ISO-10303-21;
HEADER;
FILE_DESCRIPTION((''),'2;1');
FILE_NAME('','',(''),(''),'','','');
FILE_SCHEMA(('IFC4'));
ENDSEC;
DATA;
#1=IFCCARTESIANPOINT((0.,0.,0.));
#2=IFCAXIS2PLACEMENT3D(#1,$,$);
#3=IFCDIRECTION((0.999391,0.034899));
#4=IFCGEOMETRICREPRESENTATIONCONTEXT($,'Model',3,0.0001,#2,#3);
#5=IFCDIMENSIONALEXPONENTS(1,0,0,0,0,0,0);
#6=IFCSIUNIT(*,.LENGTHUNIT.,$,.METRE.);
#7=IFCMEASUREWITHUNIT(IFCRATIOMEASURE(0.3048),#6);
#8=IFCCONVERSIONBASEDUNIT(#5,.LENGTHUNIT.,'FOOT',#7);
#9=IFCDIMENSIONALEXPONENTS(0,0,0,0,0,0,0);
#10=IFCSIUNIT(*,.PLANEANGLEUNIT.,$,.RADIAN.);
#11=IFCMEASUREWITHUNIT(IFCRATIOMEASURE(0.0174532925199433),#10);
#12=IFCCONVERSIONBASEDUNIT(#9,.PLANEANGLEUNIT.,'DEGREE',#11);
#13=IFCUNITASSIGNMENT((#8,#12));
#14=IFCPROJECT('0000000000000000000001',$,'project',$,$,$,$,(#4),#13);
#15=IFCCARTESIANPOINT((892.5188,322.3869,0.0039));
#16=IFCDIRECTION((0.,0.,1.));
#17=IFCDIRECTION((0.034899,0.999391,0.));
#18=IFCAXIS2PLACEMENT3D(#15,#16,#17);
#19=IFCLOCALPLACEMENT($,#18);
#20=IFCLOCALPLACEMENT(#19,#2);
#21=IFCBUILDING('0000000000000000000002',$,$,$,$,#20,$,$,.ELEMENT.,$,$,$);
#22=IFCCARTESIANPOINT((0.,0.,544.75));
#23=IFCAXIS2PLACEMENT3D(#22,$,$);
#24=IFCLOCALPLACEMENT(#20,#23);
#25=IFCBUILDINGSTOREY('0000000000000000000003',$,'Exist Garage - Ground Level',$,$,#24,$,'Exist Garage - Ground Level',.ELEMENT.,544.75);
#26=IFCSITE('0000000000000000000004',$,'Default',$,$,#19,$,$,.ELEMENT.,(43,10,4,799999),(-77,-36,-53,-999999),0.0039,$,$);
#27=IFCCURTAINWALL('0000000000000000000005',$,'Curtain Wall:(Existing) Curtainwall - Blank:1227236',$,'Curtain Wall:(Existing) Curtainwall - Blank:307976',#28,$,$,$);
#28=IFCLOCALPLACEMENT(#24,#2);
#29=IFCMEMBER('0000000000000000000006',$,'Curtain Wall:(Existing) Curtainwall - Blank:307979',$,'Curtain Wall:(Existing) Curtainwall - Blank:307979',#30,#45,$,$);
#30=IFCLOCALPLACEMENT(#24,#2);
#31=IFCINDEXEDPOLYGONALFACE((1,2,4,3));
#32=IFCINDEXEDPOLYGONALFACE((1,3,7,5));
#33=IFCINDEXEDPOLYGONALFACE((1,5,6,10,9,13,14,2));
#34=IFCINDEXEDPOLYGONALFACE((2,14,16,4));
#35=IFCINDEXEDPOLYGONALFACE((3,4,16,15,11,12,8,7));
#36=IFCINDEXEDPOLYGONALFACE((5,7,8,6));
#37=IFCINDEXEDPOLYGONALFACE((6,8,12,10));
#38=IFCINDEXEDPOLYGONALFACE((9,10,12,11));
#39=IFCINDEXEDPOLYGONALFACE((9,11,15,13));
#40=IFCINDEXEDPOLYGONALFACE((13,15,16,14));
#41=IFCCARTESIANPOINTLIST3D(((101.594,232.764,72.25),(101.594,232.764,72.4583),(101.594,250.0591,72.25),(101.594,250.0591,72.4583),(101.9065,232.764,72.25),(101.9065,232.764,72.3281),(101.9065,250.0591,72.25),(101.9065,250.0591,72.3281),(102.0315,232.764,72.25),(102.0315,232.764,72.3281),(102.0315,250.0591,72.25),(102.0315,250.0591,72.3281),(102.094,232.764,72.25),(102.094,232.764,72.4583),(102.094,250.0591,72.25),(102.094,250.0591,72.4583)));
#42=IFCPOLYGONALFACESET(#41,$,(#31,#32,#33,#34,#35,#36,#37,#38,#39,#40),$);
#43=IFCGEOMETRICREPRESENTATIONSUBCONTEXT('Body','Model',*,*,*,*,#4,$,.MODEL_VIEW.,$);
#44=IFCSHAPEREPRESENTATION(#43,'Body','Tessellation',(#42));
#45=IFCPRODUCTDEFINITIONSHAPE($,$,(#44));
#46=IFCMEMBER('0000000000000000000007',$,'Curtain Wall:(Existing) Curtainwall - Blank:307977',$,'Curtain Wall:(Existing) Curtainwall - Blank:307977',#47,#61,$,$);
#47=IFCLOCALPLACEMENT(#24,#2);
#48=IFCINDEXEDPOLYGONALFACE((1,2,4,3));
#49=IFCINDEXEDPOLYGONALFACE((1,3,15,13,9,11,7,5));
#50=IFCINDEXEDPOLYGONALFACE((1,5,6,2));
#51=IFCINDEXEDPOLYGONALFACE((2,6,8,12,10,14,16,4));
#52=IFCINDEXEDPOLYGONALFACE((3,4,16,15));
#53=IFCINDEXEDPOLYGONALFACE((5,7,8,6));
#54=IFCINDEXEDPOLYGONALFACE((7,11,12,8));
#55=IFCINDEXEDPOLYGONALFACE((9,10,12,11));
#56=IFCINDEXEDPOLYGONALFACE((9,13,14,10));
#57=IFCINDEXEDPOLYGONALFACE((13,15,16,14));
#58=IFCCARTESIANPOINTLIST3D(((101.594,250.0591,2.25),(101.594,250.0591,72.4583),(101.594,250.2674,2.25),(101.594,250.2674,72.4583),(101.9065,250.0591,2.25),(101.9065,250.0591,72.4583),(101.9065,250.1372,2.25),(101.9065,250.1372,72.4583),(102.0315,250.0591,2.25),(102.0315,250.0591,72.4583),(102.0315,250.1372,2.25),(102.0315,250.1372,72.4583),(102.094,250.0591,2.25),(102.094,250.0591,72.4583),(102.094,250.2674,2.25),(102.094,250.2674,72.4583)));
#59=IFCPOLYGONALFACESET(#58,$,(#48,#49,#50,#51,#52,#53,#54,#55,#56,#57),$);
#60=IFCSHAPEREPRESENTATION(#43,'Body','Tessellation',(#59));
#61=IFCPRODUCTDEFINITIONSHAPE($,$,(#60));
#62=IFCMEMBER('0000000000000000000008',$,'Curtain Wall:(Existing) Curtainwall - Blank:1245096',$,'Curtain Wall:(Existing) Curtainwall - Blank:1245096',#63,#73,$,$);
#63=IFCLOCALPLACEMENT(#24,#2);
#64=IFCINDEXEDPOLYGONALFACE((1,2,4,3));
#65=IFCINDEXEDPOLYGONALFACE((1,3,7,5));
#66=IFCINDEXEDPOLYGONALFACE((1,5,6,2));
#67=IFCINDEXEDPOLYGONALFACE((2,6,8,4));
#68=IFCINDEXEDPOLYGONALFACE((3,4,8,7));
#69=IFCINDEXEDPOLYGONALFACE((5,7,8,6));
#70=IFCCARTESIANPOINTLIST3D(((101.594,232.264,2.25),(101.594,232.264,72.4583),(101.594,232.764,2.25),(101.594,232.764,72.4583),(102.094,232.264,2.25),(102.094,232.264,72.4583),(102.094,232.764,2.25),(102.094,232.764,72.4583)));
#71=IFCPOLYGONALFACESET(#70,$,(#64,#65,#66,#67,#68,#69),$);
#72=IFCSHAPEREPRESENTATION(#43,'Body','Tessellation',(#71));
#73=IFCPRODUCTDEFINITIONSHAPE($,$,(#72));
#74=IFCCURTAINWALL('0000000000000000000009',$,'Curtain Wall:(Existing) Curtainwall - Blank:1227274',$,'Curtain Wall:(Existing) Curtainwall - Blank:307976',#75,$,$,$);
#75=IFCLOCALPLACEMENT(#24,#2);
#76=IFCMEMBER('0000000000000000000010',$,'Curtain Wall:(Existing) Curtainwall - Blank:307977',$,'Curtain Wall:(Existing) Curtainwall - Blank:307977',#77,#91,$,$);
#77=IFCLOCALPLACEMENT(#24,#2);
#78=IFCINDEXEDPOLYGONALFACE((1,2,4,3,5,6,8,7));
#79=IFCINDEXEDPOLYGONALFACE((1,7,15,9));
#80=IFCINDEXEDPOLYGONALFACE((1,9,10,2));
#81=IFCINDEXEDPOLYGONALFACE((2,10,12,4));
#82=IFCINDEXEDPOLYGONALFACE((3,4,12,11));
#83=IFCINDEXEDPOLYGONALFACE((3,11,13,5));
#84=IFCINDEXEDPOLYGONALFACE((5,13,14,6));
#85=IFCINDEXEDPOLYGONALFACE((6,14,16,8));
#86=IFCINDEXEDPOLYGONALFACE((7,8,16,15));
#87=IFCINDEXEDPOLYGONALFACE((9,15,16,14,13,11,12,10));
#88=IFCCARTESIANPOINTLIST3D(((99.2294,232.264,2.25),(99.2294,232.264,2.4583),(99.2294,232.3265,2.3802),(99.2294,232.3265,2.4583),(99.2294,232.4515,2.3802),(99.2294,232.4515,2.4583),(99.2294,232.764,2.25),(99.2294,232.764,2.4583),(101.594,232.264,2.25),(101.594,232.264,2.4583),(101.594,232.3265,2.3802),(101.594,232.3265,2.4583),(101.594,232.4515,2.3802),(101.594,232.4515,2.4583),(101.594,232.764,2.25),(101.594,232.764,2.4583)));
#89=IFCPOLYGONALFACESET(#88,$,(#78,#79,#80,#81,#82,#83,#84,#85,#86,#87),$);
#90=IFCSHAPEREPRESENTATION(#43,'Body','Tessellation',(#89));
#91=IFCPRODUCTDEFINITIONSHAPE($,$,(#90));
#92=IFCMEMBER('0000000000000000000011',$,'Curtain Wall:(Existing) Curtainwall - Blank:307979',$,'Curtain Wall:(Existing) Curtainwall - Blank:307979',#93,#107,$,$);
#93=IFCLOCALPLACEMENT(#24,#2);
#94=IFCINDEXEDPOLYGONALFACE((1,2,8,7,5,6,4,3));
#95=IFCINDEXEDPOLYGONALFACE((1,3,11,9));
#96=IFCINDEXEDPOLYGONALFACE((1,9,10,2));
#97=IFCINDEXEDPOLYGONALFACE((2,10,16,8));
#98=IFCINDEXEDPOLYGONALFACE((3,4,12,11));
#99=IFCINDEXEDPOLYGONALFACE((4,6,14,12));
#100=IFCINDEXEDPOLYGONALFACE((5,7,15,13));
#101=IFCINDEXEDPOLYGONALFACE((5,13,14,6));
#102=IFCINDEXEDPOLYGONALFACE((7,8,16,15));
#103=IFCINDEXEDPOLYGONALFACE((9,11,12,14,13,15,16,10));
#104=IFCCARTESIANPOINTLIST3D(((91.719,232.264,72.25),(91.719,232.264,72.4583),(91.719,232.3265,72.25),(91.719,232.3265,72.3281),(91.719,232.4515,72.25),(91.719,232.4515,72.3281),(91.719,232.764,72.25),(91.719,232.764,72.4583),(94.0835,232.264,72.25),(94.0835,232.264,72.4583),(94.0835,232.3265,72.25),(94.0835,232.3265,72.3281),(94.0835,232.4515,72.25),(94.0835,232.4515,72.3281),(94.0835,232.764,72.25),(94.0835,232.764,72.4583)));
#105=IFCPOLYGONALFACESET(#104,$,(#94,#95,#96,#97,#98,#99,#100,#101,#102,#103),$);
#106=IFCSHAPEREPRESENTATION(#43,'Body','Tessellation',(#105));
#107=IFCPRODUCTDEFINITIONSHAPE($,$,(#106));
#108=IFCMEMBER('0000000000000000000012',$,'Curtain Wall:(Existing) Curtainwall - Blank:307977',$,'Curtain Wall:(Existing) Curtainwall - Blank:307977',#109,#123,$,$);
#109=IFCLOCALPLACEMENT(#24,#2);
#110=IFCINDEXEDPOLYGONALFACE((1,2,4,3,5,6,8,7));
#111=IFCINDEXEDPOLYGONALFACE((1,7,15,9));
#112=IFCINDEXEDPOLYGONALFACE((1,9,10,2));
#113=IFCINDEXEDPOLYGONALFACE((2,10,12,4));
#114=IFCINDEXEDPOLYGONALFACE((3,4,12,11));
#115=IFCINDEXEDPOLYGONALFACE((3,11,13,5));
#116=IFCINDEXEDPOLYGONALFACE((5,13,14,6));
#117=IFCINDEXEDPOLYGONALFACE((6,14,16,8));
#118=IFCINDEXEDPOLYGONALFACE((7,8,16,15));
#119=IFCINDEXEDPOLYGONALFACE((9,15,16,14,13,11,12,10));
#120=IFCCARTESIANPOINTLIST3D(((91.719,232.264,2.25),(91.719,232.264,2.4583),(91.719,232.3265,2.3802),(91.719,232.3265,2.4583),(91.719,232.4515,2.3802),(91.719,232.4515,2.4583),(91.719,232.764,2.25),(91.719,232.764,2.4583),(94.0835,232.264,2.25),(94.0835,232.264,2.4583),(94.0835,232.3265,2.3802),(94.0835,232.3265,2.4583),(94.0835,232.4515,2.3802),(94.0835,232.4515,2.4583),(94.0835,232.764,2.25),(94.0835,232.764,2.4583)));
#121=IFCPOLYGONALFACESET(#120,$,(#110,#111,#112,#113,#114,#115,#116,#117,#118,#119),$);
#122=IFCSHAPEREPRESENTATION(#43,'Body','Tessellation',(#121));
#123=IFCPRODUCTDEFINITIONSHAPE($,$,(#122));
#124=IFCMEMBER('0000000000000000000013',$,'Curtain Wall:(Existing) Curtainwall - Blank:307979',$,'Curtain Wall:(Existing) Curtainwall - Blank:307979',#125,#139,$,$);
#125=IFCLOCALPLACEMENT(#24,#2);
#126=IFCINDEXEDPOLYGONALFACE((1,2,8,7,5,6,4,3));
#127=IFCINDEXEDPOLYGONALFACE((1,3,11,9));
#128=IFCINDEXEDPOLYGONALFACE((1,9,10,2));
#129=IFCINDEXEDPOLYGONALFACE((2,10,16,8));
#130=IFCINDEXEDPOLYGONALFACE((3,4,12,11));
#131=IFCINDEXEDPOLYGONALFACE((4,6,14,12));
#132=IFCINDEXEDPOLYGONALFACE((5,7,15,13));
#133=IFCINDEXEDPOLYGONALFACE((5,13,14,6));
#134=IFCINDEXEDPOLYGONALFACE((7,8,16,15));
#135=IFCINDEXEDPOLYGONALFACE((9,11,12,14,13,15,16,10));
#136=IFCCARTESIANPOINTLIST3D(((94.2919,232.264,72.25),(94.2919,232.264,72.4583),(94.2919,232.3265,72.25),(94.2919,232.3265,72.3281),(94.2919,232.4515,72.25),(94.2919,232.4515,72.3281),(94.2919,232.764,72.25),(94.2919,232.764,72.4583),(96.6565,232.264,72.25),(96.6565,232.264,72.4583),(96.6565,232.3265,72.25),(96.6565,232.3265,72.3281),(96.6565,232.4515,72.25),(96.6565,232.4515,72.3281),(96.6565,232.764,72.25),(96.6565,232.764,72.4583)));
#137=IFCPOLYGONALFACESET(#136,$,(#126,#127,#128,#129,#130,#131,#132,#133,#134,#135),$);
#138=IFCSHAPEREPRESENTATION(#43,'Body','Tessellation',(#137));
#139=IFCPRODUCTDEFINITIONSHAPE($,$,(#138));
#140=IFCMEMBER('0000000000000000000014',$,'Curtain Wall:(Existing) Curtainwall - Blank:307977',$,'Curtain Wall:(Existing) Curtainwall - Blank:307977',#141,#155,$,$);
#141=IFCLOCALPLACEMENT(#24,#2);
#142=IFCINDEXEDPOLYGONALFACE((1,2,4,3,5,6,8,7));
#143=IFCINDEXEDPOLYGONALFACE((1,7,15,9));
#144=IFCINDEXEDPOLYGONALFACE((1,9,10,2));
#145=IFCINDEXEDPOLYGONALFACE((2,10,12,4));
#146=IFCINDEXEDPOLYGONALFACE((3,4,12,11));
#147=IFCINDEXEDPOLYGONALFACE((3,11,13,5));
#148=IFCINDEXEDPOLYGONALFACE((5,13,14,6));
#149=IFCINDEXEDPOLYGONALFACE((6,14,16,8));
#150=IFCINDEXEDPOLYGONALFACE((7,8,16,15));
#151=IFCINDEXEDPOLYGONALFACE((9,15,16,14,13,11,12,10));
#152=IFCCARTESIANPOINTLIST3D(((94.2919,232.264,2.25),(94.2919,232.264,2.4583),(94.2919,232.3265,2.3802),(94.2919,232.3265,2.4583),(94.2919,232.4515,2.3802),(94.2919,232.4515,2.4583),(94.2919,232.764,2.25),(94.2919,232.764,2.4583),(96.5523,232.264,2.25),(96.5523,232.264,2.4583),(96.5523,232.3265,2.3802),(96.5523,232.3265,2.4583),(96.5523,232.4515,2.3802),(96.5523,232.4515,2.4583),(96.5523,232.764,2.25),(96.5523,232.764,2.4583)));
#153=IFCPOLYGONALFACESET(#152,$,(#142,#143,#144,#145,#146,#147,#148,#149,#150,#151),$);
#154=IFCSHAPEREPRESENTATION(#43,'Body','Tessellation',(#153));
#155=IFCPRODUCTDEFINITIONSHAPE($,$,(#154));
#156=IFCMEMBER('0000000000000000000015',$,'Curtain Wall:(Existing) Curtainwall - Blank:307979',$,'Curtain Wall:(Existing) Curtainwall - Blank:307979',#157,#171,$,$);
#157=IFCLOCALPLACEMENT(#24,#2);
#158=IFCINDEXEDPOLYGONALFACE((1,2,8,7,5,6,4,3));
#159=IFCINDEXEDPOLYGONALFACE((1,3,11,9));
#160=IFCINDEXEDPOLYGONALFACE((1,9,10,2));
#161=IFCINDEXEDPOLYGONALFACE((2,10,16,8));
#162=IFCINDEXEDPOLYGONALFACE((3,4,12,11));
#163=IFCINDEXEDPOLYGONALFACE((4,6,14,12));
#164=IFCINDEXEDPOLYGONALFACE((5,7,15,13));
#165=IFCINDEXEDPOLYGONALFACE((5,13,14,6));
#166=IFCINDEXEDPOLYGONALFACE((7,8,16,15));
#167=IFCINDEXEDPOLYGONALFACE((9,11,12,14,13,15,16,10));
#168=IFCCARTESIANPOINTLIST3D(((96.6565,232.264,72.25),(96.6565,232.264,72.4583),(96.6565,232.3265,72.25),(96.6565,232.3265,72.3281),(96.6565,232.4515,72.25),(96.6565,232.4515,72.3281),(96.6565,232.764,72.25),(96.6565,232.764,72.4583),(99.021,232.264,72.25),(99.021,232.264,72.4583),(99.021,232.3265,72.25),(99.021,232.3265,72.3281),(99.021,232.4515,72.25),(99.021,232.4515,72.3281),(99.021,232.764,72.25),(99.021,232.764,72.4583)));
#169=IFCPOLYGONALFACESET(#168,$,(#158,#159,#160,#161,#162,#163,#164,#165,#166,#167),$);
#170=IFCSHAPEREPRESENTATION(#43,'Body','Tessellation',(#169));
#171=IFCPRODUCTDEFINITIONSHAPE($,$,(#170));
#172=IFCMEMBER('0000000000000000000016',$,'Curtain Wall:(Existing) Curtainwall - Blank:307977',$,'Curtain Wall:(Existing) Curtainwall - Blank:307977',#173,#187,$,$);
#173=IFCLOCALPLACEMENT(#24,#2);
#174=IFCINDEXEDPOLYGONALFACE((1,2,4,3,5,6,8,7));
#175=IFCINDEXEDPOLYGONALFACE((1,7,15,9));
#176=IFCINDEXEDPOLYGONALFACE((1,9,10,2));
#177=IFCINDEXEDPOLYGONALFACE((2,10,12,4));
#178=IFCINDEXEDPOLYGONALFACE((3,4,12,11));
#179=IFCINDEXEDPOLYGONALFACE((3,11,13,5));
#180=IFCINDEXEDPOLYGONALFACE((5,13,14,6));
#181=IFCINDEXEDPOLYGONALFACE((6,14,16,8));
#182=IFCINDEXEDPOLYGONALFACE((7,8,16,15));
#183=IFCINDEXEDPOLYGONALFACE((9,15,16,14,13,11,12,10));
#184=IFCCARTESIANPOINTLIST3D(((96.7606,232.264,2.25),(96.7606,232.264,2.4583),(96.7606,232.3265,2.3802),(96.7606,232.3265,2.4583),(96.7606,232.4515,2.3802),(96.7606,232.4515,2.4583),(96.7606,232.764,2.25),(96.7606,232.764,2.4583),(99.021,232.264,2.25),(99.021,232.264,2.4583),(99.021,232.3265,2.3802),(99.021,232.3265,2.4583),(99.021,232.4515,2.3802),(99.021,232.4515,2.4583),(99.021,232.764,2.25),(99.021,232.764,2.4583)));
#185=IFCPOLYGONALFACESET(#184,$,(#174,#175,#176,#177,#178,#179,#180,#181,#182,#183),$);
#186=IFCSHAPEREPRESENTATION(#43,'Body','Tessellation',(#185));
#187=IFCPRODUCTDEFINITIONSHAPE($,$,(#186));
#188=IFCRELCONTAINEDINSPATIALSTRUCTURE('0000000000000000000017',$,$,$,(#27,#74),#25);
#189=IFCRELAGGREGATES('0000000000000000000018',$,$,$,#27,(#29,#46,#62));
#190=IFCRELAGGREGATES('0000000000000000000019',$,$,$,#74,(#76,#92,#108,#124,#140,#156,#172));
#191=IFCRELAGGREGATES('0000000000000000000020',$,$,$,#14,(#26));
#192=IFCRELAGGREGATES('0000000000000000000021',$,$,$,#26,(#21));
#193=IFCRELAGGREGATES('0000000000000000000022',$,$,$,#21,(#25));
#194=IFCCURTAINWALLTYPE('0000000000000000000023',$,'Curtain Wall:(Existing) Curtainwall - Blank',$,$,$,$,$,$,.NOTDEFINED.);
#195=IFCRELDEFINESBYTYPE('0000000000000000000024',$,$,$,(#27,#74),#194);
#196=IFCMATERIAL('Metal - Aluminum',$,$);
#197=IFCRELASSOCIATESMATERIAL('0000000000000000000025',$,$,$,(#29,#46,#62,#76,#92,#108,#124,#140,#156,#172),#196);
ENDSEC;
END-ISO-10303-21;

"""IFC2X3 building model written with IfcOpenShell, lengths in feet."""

from ifc_helpers import new_model, entity, si_unit, converted_unit, direction, frame, origin, origin_2d_with_axis, place, context, subcontext, project, spatial, polyline, rectangle, outline, extrude, material, type_object, element, aggregate, save


model = new_model("IFC2X3")

# Units and contexts
model_context = context("Model", 3, precision=0.0001, world=origin(), true_north=direction((0.999391, 0.034899)))
body_context = subcontext(model_context, "Body", "Model", "MODEL_VIEW")
ifc_project = project(units=[converted_unit("LENGTHUNIT", "FOOT", entity("IfcRatioMeasure", 0.3048), si_unit("LENGTHUNIT", "METRE"), dimensions=[1, 0, 0, 0, 0, 0, 0]), converted_unit("PLANEANGLEUNIT", "DEGREE", entity("IfcRatioMeasure", 0.0174532925199433), si_unit("PLANEANGLEUNIT", "RADIAN"), dimensions=[0, 0, 0, 0, 0, 0, 0])], contexts=[model_context])

# Site, building, storey
site_placement = place(None, frame((892.5188, 322.3869, 0.0039), z_axis=(0.0, 0.0, 1.0), x_axis=(0.034899, 0.999391, 0.0)))
site = spatial("IfcSite", under=ifc_project, at=site_placement, Name="Default", CompositionType="ELEMENT", RefLatitude=(43, 10, 4, 799999), RefLongitude=(-77, -36, -53, -999999), RefElevation=0.0039)
building_placement = place(site_placement, origin())
building = spatial("IfcBuilding", under=site, at=building_placement, CompositionType="ELEMENT")
storey_placement = place(building_placement, frame((0.0, 0.0, 544.75)))
storey = spatial("IfcBuildingStorey", under=building, at=storey_placement, Name="Exist Garage - Ground Level", LongName="Exist Garage - Ground Level", CompositionType="ELEMENT", Elevation=544.75)

# Curtain walls, members
curtain_wall_type = type_object("IfcCurtainWallType", Name="Curtain Wall:(Existing) Curtainwall - Blank", PredefinedType="NOTDEFINED")
curtain_wall_1_placement = place(storey_placement, frame((0.0, 0.0, -544.75)))
curtain_wall_1 = element("IfcCurtainWall", 1, at=curtain_wall_1_placement, inside=storey, type_object=curtain_wall_type, Name="Curtain Wall:(Existing) Curtainwall - Blank:1227236", ObjectType="Curtain Wall:(Existing) Curtainwall - Blank:307976")
ifc_material_1 = material(Name="Metal - Aluminum")
member_1_placement = place(curtain_wall_1_placement, frame((0.0, 0.0, 544.75)))
member_1 = element("IfcMember", 2, at=member_1_placement, material=ifc_material_1, Name="Curtain Wall:(Existing) Curtainwall - Blank:307979", ObjectType="Curtain Wall:(Existing) Curtainwall - Blank:307979", context=body_context, shape_type="SweptSolid", body=[
    extrude(outline(polyline([(-0.1367, -0.1875), (0.0716, -0.1875), (0.0716, -0.125), (-0.0065, -0.125), (-0.0065, 0.0), (0.0716, 0.0), (0.0716, 0.3125), (-0.1367, 0.3125), (-0.1367, -0.1875)])), frame((101.9065, 232.764, 72.3216), z_axis=(0.0, 1.0, 0.0), x_axis=(0.0, 0.0, -1.0)), (0.0, 0.0, 1.0), 17.2951),
])
member_2_placement = place(curtain_wall_1_placement, frame((0.0, 0.0, 544.75)))
member_2 = element("IfcMember", 3, at=member_2_placement, material=ifc_material_1, Name="Curtain Wall:(Existing) Curtainwall - Blank:307977", ObjectType="Curtain Wall:(Existing) Curtainwall - Blank:307977", context=body_context, shape_type="SweptSolid", body=[
    extrude(outline(polyline([(0.0, -0.0716), (0.3125, -0.0716), (0.3125, 0.1367), (-0.1875, 0.1367), (-0.1875, -0.0716), (-0.125, -0.0716), (-0.125, 0.0065), (0.0, 0.0065), (0.0, -0.0716)])), frame((101.9065, 250.1307, 72.4583), z_axis=(0.0, 0.0, -1.0), x_axis=(-1.0, 0.0, 0.0)), (0.0, 0.0, 1.0), 70.2083),
])
member_3_placement = place(curtain_wall_1_placement, frame((0.0, 0.0, 544.75)))
member_3 = element("IfcMember", 4, at=member_3_placement, material=ifc_material_1, Name="Curtain Wall:(Existing) Curtainwall - Blank:1245096", ObjectType="Curtain Wall:(Existing) Curtainwall - Blank:1245096", context=body_context, shape_type="SweptSolid", body=[
    extrude(rectangle(XDim=0.5, YDim=0.5, at=origin_2d_with_axis()), frame((101.844, 232.514, 2.25), z_axis=(0.0, 0.0, 1.0), x_axis=(-1.0, 0.0, 0.0)), (0.0, 0.0, 1.0), 70.2083),
])
aggregate(curtain_wall_1, [member_1, member_2, member_3])
curtain_wall_2_placement = place(storey_placement, frame((0.0, 0.0, -544.75)))
curtain_wall_2 = element("IfcCurtainWall", 5, at=curtain_wall_2_placement, inside=storey, type_object=curtain_wall_type, Name="Curtain Wall:(Existing) Curtainwall - Blank:1227274", ObjectType="Curtain Wall:(Existing) Curtainwall - Blank:307976")
member_4_placement = place(curtain_wall_2_placement, frame((0.0, 0.0, 544.75)))
member_4 = element("IfcMember", 6, at=member_4_placement, material=ifc_material_1, Name="Curtain Wall:(Existing) Curtainwall - Blank:307977", ObjectType="Curtain Wall:(Existing) Curtainwall - Blank:307977", context=body_context, shape_type="SweptSolid", body=[
    extrude(outline(polyline([(-0.0716, -0.3125), (0.1367, -0.3125), (0.1367, 0.1875), (-0.0716, 0.1875), (-0.0716, 0.125), (0.0065, 0.125), (0.0065, 0.0), (-0.0716, 0.0), (-0.0716, -0.3125)])), frame((101.594, 232.4515, 2.3867), z_axis=(-1.0, 0.0, 0.0), x_axis=(0.0, 0.0, -1.0)), (0.0, 0.0, 1.0), 2.3646),
])
member_5_placement = place(curtain_wall_2_placement, frame((0.0, 0.0, 544.75)))
member_5 = element("IfcMember", 7, at=member_5_placement, material=ifc_material_1, Name="Curtain Wall:(Existing) Curtainwall - Blank:307979", ObjectType="Curtain Wall:(Existing) Curtainwall - Blank:307979", context=body_context, shape_type="SweptSolid", body=[
    extrude(outline(polyline([(-0.1367, -0.1875), (0.0716, -0.1875), (0.0716, -0.125), (-0.0065, -0.125), (-0.0065, 0.0), (0.0716, 0.0), (0.0716, 0.3125), (-0.1367, 0.3125), (-0.1367, -0.1875)])), frame((91.719, 232.4515, 72.3216), z_axis=(1.0, 0.0, 0.0), x_axis=(0.0, 0.0, -1.0)), (0.0, 0.0, 1.0), 2.3646),
])
member_6_placement = place(curtain_wall_2_placement, frame((0.0, 0.0, 544.75)))
member_6 = element("IfcMember", 8, at=member_6_placement, material=ifc_material_1, Name="Curtain Wall:(Existing) Curtainwall - Blank:307977", ObjectType="Curtain Wall:(Existing) Curtainwall - Blank:307977", context=body_context, shape_type="SweptSolid", body=[
    extrude(outline(polyline([(-0.0716, -0.3125), (0.1367, -0.3125), (0.1367, 0.1875), (-0.0716, 0.1875), (-0.0716, 0.125), (0.0065, 0.125), (0.0065, 0.0), (-0.0716, 0.0), (-0.0716, -0.3125)])), frame((94.0835, 232.4515, 2.3867), z_axis=(-1.0, 0.0, 0.0), x_axis=(0.0, 0.0, -1.0)), (0.0, 0.0, 1.0), 2.3646),
])
member_7_placement = place(curtain_wall_2_placement, frame((0.0, 0.0, 544.75)))
member_7 = element("IfcMember", 9, at=member_7_placement, material=ifc_material_1, Name="Curtain Wall:(Existing) Curtainwall - Blank:307979", ObjectType="Curtain Wall:(Existing) Curtainwall - Blank:307979", context=body_context, shape_type="SweptSolid", body=[
    extrude(outline(polyline([(-0.1367, -0.1875), (0.0716, -0.1875), (0.0716, -0.125), (-0.0065, -0.125), (-0.0065, 0.0), (0.0716, 0.0), (0.0716, 0.3125), (-0.1367, 0.3125), (-0.1367, -0.1875)])), frame((94.2919, 232.4515, 72.3216), z_axis=(1.0, 0.0, 0.0), x_axis=(0.0, 0.0, -1.0)), (0.0, 0.0, 1.0), 2.3646),
])
member_8_placement = place(curtain_wall_2_placement, frame((0.0, 0.0, 544.75)))
member_8 = element("IfcMember", 10, at=member_8_placement, material=ifc_material_1, Name="Curtain Wall:(Existing) Curtainwall - Blank:307977", ObjectType="Curtain Wall:(Existing) Curtainwall - Blank:307977", context=body_context, shape_type="SweptSolid", body=[
    extrude(outline(polyline([(-0.0716, -0.3125), (0.1367, -0.3125), (0.1367, 0.1875), (-0.0716, 0.1875), (-0.0716, 0.125), (0.0065, 0.125), (0.0065, 0.0), (-0.0716, 0.0), (-0.0716, -0.3125)])), frame((96.5523, 232.4515, 2.3867), z_axis=(-1.0, 0.0, 0.0), x_axis=(0.0, 0.0, -1.0)), (0.0, 0.0, 1.0), 2.2604),
])
member_9_placement = place(curtain_wall_2_placement, frame((0.0, 0.0, 544.75)))
member_9 = element("IfcMember", 11, at=member_9_placement, material=ifc_material_1, Name="Curtain Wall:(Existing) Curtainwall - Blank:307979", ObjectType="Curtain Wall:(Existing) Curtainwall - Blank:307979", context=body_context, shape_type="SweptSolid", body=[
    extrude(outline(polyline([(-0.1367, -0.1875), (0.0716, -0.1875), (0.0716, -0.125), (-0.0065, -0.125), (-0.0065, 0.0), (0.0716, 0.0), (0.0716, 0.3125), (-0.1367, 0.3125), (-0.1367, -0.1875)])), frame((96.6565, 232.4515, 72.3216), z_axis=(1.0, 0.0, 0.0), x_axis=(0.0, 0.0, -1.0)), (0.0, 0.0, 1.0), 2.3646),
])
member_10_placement = place(curtain_wall_2_placement, frame((0.0, 0.0, 544.75)))
member_10 = element("IfcMember", 12, at=member_10_placement, material=ifc_material_1, Name="Curtain Wall:(Existing) Curtainwall - Blank:307977", ObjectType="Curtain Wall:(Existing) Curtainwall - Blank:307977", context=body_context, shape_type="SweptSolid", body=[
    extrude(outline(polyline([(-0.0716, -0.3125), (0.1367, -0.3125), (0.1367, 0.1875), (-0.0716, 0.1875), (-0.0716, 0.125), (0.0065, 0.125), (0.0065, 0.0), (-0.0716, 0.0), (-0.0716, -0.3125)])), frame((99.021, 232.4515, 2.3867), z_axis=(-1.0, 0.0, 0.0), x_axis=(0.0, 0.0, -1.0)), (0.0, 0.0, 1.0), 2.2604),
])
aggregate(curtain_wall_2, [member_4, member_5, member_6, member_7, member_8, member_9, member_10])

save(model, "model.ifc")
